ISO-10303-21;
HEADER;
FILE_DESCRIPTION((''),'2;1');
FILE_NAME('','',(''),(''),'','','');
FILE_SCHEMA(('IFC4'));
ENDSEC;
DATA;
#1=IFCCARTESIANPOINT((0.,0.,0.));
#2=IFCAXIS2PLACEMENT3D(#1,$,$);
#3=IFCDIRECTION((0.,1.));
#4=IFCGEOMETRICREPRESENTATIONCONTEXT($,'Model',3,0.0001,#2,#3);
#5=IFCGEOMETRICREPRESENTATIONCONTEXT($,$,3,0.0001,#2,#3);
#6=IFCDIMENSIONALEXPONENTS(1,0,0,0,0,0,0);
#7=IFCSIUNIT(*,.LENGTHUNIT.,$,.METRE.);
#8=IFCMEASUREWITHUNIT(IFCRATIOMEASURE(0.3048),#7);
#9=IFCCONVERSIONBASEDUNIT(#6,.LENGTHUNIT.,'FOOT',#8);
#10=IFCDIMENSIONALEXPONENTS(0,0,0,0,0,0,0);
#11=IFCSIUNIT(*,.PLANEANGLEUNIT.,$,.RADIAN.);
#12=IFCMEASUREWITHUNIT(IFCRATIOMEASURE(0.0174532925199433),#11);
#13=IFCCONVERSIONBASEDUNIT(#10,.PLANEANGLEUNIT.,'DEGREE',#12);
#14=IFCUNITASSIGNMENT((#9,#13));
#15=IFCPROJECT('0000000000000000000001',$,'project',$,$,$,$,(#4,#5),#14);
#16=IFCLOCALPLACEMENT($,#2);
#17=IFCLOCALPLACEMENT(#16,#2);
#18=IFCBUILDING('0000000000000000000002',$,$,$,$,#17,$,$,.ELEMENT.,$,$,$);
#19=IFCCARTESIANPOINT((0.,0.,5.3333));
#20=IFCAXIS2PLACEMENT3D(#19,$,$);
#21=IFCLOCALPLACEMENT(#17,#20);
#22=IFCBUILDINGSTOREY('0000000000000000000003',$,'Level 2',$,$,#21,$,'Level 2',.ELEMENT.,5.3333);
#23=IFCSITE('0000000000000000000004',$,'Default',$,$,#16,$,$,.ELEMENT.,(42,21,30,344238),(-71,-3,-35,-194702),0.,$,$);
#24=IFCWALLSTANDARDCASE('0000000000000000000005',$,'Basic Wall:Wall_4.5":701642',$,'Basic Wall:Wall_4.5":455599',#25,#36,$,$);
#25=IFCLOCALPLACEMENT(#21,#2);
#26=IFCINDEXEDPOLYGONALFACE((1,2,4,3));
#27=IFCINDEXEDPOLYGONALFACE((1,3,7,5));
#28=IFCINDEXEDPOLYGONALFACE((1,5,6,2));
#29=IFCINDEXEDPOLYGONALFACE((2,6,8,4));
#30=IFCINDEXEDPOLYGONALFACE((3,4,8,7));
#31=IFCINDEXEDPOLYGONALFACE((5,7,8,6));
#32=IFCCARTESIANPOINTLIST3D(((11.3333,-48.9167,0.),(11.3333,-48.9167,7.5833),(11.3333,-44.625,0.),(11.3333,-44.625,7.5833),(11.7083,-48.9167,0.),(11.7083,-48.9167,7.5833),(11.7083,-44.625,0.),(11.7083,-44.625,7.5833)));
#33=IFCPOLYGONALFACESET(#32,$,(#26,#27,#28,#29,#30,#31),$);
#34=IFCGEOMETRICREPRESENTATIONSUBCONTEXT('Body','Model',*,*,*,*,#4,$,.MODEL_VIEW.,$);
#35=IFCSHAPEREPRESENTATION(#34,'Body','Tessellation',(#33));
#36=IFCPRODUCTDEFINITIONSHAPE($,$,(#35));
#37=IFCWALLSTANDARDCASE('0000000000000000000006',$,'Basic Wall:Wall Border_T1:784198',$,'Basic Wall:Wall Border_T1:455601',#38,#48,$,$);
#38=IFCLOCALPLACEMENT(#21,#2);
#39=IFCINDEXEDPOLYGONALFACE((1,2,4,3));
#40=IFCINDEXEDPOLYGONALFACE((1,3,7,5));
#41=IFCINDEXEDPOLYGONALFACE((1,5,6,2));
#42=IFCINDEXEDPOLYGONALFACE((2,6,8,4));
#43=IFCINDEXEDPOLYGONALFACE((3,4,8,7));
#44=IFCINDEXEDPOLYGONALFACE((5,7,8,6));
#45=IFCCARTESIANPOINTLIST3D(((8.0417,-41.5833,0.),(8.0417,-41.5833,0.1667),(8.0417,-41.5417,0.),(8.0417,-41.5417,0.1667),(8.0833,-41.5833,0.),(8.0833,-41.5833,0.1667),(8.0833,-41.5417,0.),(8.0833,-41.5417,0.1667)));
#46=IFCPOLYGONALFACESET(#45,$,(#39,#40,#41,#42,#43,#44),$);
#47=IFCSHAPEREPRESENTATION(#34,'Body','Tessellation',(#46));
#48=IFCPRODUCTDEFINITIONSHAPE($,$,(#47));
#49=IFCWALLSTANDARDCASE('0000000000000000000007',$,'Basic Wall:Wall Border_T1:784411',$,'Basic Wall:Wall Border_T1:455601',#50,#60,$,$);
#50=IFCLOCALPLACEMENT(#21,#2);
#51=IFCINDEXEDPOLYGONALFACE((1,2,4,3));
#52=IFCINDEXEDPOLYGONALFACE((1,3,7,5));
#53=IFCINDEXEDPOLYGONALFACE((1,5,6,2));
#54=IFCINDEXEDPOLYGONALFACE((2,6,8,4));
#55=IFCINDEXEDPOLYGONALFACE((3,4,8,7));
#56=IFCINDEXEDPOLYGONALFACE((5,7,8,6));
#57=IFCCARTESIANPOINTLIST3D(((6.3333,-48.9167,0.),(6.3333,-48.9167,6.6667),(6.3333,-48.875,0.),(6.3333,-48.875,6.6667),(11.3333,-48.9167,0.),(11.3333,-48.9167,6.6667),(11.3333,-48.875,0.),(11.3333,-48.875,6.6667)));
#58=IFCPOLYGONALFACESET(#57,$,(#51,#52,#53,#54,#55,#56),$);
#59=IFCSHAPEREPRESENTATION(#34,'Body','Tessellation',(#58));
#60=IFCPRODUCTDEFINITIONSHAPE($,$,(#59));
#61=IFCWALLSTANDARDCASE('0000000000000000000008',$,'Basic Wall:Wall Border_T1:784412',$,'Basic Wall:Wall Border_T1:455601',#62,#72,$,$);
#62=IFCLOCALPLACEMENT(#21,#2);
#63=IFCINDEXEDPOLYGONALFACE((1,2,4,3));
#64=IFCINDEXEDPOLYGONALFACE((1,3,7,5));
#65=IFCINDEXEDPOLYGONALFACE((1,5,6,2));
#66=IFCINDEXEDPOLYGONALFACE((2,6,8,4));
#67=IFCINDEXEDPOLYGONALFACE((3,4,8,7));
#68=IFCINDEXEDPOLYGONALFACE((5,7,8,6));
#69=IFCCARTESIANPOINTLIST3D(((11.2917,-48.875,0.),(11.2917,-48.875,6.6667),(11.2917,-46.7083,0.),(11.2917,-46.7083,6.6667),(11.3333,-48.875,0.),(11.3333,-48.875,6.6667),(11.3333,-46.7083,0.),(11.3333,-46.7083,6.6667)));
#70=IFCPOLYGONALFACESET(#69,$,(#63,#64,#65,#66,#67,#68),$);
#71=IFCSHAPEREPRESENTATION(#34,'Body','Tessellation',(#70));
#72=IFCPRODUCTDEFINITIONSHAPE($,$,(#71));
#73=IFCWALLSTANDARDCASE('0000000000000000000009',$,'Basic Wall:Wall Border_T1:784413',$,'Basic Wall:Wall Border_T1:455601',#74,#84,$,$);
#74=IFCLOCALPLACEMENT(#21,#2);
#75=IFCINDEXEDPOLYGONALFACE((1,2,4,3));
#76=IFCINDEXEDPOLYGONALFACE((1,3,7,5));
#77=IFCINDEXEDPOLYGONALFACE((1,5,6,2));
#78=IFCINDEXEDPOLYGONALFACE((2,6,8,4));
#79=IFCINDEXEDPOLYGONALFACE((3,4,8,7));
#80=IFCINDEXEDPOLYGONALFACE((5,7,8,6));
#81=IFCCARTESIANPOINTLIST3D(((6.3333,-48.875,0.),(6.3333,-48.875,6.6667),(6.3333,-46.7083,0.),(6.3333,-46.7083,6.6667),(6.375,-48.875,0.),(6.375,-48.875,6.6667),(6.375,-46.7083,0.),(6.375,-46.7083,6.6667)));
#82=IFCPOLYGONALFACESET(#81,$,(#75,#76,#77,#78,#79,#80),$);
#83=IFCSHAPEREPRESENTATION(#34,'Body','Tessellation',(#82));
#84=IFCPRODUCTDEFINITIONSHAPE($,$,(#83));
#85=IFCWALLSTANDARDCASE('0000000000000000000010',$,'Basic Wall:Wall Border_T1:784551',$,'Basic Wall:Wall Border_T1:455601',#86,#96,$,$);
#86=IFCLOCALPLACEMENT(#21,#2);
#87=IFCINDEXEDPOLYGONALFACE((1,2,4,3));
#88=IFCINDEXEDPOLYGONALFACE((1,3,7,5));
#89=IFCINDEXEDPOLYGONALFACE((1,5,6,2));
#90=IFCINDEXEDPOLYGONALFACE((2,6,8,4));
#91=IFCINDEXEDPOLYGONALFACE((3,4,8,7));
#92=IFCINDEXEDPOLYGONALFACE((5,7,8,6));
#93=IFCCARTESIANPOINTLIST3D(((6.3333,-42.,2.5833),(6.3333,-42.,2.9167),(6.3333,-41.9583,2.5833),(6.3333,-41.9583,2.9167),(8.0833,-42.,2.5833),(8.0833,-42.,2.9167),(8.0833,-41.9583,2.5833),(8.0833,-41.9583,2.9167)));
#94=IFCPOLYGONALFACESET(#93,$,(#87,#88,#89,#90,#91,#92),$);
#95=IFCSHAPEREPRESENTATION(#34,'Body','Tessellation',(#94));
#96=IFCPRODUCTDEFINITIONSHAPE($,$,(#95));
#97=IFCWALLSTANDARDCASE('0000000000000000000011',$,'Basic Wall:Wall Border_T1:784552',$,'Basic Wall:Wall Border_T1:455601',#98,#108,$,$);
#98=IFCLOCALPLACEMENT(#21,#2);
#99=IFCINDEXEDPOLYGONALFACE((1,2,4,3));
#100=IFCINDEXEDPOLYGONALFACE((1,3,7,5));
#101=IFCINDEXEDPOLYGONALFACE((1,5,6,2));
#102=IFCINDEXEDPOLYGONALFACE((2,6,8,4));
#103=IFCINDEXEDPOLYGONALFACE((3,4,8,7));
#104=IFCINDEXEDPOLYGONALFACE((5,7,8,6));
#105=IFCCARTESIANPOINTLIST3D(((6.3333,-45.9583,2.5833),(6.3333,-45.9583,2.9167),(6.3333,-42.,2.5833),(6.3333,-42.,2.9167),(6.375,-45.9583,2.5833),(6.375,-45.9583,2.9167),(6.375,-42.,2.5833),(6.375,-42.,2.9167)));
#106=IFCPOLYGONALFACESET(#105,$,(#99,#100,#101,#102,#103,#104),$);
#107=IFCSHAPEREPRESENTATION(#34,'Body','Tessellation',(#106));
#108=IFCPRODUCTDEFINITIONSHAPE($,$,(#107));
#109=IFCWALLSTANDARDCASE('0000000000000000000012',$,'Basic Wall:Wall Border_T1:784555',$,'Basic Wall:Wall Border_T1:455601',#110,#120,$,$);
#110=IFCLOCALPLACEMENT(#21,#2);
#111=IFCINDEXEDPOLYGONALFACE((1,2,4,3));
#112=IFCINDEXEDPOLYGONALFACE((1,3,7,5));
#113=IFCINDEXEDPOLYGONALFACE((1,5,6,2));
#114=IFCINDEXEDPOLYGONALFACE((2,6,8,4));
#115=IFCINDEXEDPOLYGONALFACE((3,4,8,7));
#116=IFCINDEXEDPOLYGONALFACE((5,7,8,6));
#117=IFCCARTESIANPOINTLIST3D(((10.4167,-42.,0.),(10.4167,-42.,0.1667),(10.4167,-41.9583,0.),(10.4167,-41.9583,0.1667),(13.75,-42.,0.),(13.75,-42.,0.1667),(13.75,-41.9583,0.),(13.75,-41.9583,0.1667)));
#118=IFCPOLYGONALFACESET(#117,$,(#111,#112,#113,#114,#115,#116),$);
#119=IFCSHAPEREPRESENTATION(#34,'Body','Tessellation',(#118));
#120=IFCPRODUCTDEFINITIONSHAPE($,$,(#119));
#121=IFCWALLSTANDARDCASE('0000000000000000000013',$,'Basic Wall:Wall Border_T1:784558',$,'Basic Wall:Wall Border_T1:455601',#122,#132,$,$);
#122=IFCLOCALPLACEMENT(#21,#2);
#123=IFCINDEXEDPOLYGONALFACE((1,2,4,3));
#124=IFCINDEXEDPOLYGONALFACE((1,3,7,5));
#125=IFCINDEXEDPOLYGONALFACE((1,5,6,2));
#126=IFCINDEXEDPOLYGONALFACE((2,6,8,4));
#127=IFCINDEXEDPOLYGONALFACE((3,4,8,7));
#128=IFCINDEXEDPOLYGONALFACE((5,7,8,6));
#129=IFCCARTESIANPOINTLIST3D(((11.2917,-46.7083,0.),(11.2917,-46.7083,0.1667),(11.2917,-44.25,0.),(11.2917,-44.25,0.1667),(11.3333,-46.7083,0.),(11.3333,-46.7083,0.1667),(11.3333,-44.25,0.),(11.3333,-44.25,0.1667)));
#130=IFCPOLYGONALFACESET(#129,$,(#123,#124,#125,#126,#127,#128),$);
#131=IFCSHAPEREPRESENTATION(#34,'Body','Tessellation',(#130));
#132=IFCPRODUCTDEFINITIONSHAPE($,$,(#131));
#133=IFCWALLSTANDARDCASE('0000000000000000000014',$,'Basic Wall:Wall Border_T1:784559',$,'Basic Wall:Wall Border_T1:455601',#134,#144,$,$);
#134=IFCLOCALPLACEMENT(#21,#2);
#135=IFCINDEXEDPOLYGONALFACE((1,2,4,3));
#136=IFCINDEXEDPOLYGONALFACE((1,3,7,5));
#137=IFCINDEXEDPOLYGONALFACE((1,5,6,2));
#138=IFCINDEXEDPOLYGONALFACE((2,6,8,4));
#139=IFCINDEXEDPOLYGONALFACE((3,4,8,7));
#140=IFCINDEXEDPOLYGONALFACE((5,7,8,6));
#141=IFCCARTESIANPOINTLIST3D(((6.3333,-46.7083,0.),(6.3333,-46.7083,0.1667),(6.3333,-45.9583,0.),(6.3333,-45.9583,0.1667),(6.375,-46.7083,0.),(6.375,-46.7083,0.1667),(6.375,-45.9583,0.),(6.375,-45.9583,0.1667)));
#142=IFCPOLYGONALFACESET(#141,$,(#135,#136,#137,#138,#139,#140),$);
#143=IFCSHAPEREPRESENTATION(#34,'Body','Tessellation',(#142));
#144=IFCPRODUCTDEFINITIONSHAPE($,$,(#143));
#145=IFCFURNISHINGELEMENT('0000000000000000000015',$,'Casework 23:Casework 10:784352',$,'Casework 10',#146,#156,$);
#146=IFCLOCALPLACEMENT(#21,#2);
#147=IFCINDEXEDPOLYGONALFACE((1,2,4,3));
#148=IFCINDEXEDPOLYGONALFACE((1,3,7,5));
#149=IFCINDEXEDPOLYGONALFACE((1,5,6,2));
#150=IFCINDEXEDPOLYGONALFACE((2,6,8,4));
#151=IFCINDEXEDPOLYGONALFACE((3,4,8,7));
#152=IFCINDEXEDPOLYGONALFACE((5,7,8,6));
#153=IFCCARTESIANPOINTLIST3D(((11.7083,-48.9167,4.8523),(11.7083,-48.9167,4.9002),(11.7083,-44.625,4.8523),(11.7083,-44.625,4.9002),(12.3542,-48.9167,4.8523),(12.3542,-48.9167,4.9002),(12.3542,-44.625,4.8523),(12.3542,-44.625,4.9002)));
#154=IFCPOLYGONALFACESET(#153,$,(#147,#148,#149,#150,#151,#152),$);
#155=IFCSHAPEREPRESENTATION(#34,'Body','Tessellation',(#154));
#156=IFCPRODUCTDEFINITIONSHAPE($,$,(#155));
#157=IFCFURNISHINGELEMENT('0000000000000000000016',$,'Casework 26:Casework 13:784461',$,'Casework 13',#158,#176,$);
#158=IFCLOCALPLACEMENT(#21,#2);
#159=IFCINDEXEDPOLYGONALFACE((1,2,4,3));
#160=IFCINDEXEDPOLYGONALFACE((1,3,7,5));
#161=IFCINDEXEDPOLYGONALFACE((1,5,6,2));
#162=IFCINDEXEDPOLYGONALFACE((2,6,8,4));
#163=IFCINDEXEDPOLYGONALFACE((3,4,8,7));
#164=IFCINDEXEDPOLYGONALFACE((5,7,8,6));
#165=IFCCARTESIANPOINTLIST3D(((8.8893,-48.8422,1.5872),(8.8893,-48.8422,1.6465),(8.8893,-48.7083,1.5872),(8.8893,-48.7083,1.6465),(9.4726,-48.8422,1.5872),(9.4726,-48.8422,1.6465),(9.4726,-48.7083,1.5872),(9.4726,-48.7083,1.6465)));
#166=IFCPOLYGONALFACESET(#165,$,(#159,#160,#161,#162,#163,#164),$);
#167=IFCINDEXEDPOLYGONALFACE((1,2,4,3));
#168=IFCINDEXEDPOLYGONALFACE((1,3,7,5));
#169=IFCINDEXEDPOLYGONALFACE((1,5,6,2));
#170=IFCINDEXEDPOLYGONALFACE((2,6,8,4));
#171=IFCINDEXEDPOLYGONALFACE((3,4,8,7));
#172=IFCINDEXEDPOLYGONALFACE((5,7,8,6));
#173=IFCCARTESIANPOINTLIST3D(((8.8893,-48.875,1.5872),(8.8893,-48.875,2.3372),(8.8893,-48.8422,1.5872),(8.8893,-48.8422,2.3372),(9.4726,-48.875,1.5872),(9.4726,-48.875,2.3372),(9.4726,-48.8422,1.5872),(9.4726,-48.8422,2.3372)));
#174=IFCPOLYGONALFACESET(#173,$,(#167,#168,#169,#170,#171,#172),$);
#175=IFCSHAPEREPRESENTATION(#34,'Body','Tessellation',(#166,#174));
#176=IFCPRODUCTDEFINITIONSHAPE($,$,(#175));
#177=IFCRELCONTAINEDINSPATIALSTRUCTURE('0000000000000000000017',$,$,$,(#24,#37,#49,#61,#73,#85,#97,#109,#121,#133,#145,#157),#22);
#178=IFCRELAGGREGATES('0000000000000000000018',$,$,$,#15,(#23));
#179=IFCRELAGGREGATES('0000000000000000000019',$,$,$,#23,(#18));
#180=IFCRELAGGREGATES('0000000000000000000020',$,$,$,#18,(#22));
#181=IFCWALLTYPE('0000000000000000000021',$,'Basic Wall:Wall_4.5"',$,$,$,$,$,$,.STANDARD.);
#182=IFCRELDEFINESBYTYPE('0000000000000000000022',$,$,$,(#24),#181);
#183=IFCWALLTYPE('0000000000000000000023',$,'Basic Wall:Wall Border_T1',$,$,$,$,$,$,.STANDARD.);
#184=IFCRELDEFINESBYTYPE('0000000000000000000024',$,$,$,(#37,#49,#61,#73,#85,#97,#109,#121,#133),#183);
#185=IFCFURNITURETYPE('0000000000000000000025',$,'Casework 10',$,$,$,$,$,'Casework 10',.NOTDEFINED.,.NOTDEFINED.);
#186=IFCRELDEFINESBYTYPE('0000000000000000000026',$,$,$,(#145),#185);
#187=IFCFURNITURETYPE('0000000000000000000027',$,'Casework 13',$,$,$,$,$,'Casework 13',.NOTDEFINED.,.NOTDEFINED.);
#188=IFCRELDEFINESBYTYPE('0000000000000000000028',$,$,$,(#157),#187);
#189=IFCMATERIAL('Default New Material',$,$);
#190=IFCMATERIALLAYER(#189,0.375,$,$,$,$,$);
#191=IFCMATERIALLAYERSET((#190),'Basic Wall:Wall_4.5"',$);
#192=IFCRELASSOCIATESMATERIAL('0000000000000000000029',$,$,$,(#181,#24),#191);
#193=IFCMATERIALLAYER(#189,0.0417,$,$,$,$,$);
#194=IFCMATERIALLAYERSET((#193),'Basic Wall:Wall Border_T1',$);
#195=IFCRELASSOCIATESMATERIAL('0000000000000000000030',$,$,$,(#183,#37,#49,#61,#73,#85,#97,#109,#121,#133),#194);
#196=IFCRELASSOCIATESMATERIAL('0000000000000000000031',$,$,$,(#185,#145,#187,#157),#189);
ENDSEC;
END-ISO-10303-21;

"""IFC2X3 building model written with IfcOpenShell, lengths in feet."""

from ifc_helpers import new_model, entity, si_unit, converted_unit, direction, frame, frame_2d, origin, place, context, subcontext, project, spatial, rectangle, extrude, source, transform, mapped, material, layer, layer_set, layer_usage, type_object, type_shapes, element, save


model = new_model("IFC2X3")

# Units and contexts
model_context = context("Model", 3, precision=0.0001, world=origin(), true_north=direction((0.0, 1.0)))
context_of_model = context(None, 3, precision=0.0001, world=origin(), true_north=direction((0.0, 1.0)))
body_context = subcontext(model_context, "Body", "Model", "MODEL_VIEW")
ifc_project = project(units=[converted_unit("LENGTHUNIT", "FOOT", entity("IfcRatioMeasure", 0.3048), si_unit("LENGTHUNIT", "METRE"), dimensions=[1, 0, 0, 0, 0, 0, 0]), converted_unit("PLANEANGLEUNIT", "DEGREE", entity("IfcRatioMeasure", 0.0174532925199433), si_unit("PLANEANGLEUNIT", "RADIAN"), dimensions=[0, 0, 0, 0, 0, 0, 0])], contexts=[model_context, context_of_model])

# Site, building, storey
site_placement = place(None, origin())
site = spatial("IfcSite", under=ifc_project, at=site_placement, Name="Default", CompositionType="ELEMENT", RefLatitude=(42, 21, 30, 344238), RefLongitude=(-71, -3, -35, -194702), RefElevation=0.0)
building_placement = place(site_placement, origin())
building = spatial("IfcBuilding", under=site, at=building_placement, CompositionType="ELEMENT")
storey_placement = place(building_placement, frame((0.0, 0.0, 5.3333)))
storey = spatial("IfcBuildingStorey", under=building, at=storey_placement, Name="Level 2", LongName="Level 2", CompositionType="ELEMENT", Elevation=5.3333)

# Walls
ifc_material = material(Name="Default New Material")
ifc_layer_1 = layer(ifc_material, 0.375)
ifc_layer_set_1 = layer_set([ifc_layer_1], Name="Basic Wall:Wall_4.5\"")
ifc_layer_usage_1 = layer_usage(ifc_layer_set_1, "AXIS2", "NEGATIVE", 0.1875)
wall_type_1 = type_object("IfcWallType", Name="Basic Wall:Wall_4.5\"", PredefinedType="STANDARD", material=ifc_layer_set_1)
wall_1_placement = place(storey_placement, frame((11.5208, -44.625, 0.0), z_axis=(0.0, 0.0, 1.0), x_axis=(0.0, -1.0, 0.0)))
element("IfcWallStandardCase", 1, at=wall_1_placement, inside=storey, type_object=wall_type_1, material=ifc_layer_usage_1, Name="Basic Wall:Wall_4.5\":701642", ObjectType="Basic Wall:Wall_4.5\":455599", context=body_context, shape_type="SweptSolid", body=[
    extrude(rectangle(XDim=4.2917, YDim=0.375, at=frame_2d((2.1458, 0.0), x_axis=(-1.0, 0.0))), origin(), (0.0, 0.0, 1.0), 7.5833),
])
ifc_layer_2 = layer(ifc_material, 0.0417)
ifc_layer_set_2 = layer_set([ifc_layer_2], Name="Basic Wall:Wall Border_T1")
ifc_layer_usage_2 = layer_usage(ifc_layer_set_2, "AXIS2", "NEGATIVE", 0.0208)
wall_type_2 = type_object("IfcWallType", Name="Basic Wall:Wall Border_T1", PredefinedType="STANDARD", material=ifc_layer_set_2)
wall_2_placement = place(storey_placement, frame((8.0417, -41.5625, 0.0)))
element("IfcWallStandardCase", 2, at=wall_2_placement, inside=storey, type_object=wall_type_2, material=ifc_layer_usage_2, Name="Basic Wall:Wall Border_T1:784198", ObjectType="Basic Wall:Wall Border_T1:455601", context=body_context, shape_type="SweptSolid", body=[
    extrude(rectangle(XDim=0.0417, YDim=0.0417, at=frame_2d((0.0208, 0.0), x_axis=(-1.0, 0.0))), origin(), (0.0, 0.0, 1.0), 0.1667),
])
ifc_layer_usage_3 = layer_usage(ifc_layer_set_2, "AXIS2", "NEGATIVE", 0.0208)
wall_3_placement = place(storey_placement, frame((6.3333, -48.8958, 0.0)))
element("IfcWallStandardCase", 3, at=wall_3_placement, inside=storey, type_object=wall_type_2, material=ifc_layer_usage_3, Name="Basic Wall:Wall Border_T1:784411", ObjectType="Basic Wall:Wall Border_T1:455601", context=body_context, shape_type="SweptSolid", body=[
    extrude(rectangle(XDim=5.0, YDim=0.0417, at=frame_2d((2.5, 0.0), x_axis=(-1.0, 0.0))), origin(), (0.0, 0.0, 1.0), 6.6667),
])
ifc_layer_usage_4 = layer_usage(ifc_layer_set_2, "AXIS2", "NEGATIVE", 0.0208)
wall_4_placement = place(storey_placement, frame((11.3125, -48.875, 0.0), z_axis=(0.0, 0.0, 1.0), x_axis=(0.0, 1.0, 0.0)))
element("IfcWallStandardCase", 4, at=wall_4_placement, inside=storey, type_object=wall_type_2, material=ifc_layer_usage_4, Name="Basic Wall:Wall Border_T1:784412", ObjectType="Basic Wall:Wall Border_T1:455601", context=body_context, shape_type="SweptSolid", body=[
    extrude(rectangle(XDim=2.1667, YDim=0.0417, at=frame_2d((1.0833, 0.0), x_axis=(-1.0, 0.0))), origin(), (0.0, 0.0, 1.0), 6.6667),
])
ifc_layer_usage_5 = layer_usage(ifc_layer_set_2, "AXIS2", "POSITIVE", -0.0208)
wall_5_placement = place(storey_placement, frame((6.3542, -48.875, 0.0), z_axis=(0.0, 0.0, 1.0), x_axis=(0.0, 1.0, 0.0)))
element("IfcWallStandardCase", 5, at=wall_5_placement, inside=storey, type_object=wall_type_2, material=ifc_layer_usage_5, Name="Basic Wall:Wall Border_T1:784413", ObjectType="Basic Wall:Wall Border_T1:455601", context=body_context, shape_type="SweptSolid", body=[
    extrude(rectangle(XDim=2.1667, YDim=0.0417, at=frame_2d((1.0833, 0.0), x_axis=(-1.0, 0.0))), origin(), (0.0, 0.0, 1.0), 6.6667),
])
ifc_layer_usage_6 = layer_usage(ifc_layer_set_2, "AXIS2", "NEGATIVE", 0.0208)
wall_6_placement = place(storey_placement, frame((8.0833, -41.9792, 2.5833), z_axis=(0.0, 0.0, 1.0), x_axis=(-1.0, 0.0, 0.0)))
element("IfcWallStandardCase", 6, at=wall_6_placement, inside=storey, type_object=wall_type_2, material=ifc_layer_usage_6, Name="Basic Wall:Wall Border_T1:784551", ObjectType="Basic Wall:Wall Border_T1:455601", context=body_context, shape_type="SweptSolid", body=[
    extrude(rectangle(XDim=1.75, YDim=0.0417, at=frame_2d((0.875, 0.0), x_axis=(-1.0, 0.0))), origin(), (0.0, 0.0, 1.0), 0.3333),
])
ifc_layer_usage_7 = layer_usage(ifc_layer_set_2, "AXIS2", "NEGATIVE", 0.0208)
wall_7_placement = place(storey_placement, frame((6.3542, -42.0, 2.5833), z_axis=(0.0, 0.0, 1.0), x_axis=(0.0, -1.0, 0.0)))
element("IfcWallStandardCase", 7, at=wall_7_placement, inside=storey, type_object=wall_type_2, material=ifc_layer_usage_7, Name="Basic Wall:Wall Border_T1:784552", ObjectType="Basic Wall:Wall Border_T1:455601", context=body_context, shape_type="SweptSolid", body=[
    extrude(rectangle(XDim=3.9583, YDim=0.0417, at=frame_2d((1.9792, 0.0), x_axis=(-1.0, 0.0))), origin(), (0.0, 0.0, 1.0), 0.3333),
])
ifc_layer_usage_8 = layer_usage(ifc_layer_set_2, "AXIS2", "POSITIVE", -0.0208)
wall_8_placement = place(storey_placement, frame((10.4167, -41.9792, 0.0)))
element("IfcWallStandardCase", 8, at=wall_8_placement, inside=storey, type_object=wall_type_2, material=ifc_layer_usage_8, Name="Basic Wall:Wall Border_T1:784555", ObjectType="Basic Wall:Wall Border_T1:455601", context=body_context, shape_type="SweptSolid", body=[
    extrude(rectangle(XDim=3.3333, YDim=0.0417, at=frame_2d((1.6667, 0.0), x_axis=(-1.0, 0.0))), origin(), (0.0, 0.0, 1.0), 0.1667),
])
ifc_layer_usage_9 = layer_usage(ifc_layer_set_2, "AXIS2", "POSITIVE", -0.0208)
wall_9_placement = place(storey_placement, frame((11.3125, -44.25, 0.0), z_axis=(0.0, 0.0, 1.0), x_axis=(0.0, -1.0, 0.0)))
element("IfcWallStandardCase", 9, at=wall_9_placement, inside=storey, type_object=wall_type_2, material=ifc_layer_usage_9, Name="Basic Wall:Wall Border_T1:784558", ObjectType="Basic Wall:Wall Border_T1:455601", context=body_context, shape_type="SweptSolid", body=[
    extrude(rectangle(XDim=2.4583, YDim=0.0417, at=frame_2d((1.2292, 0.0), x_axis=(-1.0, 0.0))), origin(), (0.0, 0.0, 1.0), 0.1667),
])
ifc_layer_usage_10 = layer_usage(ifc_layer_set_2, "AXIS2", "POSITIVE", -0.0208)
wall_10_placement = place(storey_placement, frame((6.3542, -46.7083, 0.0), z_axis=(0.0, 0.0, 1.0), x_axis=(0.0, 1.0, 0.0)))
element("IfcWallStandardCase", 10, at=wall_10_placement, inside=storey, type_object=wall_type_2, material=ifc_layer_usage_10, Name="Basic Wall:Wall Border_T1:784559", ObjectType="Basic Wall:Wall Border_T1:455601", context=body_context, shape_type="SweptSolid", body=[
    extrude(rectangle(XDim=0.75, YDim=0.0417, at=frame_2d((0.375, 0.0), x_axis=(-1.0, 0.0))), origin(), (0.0, 0.0, 1.0), 0.1667),
])

# Furnishing elements
furniture_type_1 = type_object("IfcFurnitureType", Name="Casework 10", ElementType="Casework 10", AssemblyPlace="NOTDEFINED", material=ifc_material)
shared_shape_1 = source(origin(), body_context, "Body", "SweptSolid", [
    extrude(rectangle(XDim=0.6458, YDim=4.2917, at=frame_2d((0.0, 0.0), x_axis=(1.0, 0.0))), frame((0.3229, 2.1458, 0.0), z_axis=(0.0, 0.0, 1.0), x_axis=(-1.0, 0.0, 0.0)), (0.0, 0.0, 1.0), 0.0479),
])
type_shapes(furniture_type_1, [shared_shape_1])
furnishing_1_placement = place(storey_placement, frame((11.7083, -48.9167, 4.8523)))
element("IfcFurnishingElement", 11, at=furnishing_1_placement, inside=storey, type_object=furniture_type_1, material=ifc_material, Name="Casework 23:Casework 10:784352", ObjectType="Casework 10", context=body_context, shape_type="MappedRepresentation", body=[
    mapped(shared_shape_1, transform((0.0, 0.0, 0.0), scale=1.0)),
])
furniture_type_2 = type_object("IfcFurnitureType", Name="Casework 13", ElementType="Casework 13", AssemblyPlace="NOTDEFINED", material=ifc_material)
shared_shape_2 = source(origin(), body_context, "Body", "SweptSolid", [
    extrude(rectangle(XDim=0.1339, YDim=0.5833, at=frame_2d((0.0, 0.0), x_axis=(1.0, 0.0))), frame((0.2917, 0.0997, 0.0), z_axis=(0.0, 0.0, 1.0), x_axis=(0.0, -1.0, 0.0)), (0.0, 0.0, 1.0), 0.0593),
    extrude(rectangle(XDim=0.0328, YDim=0.5833, at=frame_2d((0.0, 0.0), x_axis=(1.0, 0.0))), frame((0.2917, 0.0164, 0.0), z_axis=(0.0, 0.0, 1.0), x_axis=(0.0, -1.0, 0.0)), (0.0, 0.0, 1.0), 0.75),
])
type_shapes(furniture_type_2, [shared_shape_2])
furnishing_2_placement = place(storey_placement, frame((8.8893, -48.875, 1.5872)))
element("IfcFurnishingElement", 12, at=furnishing_2_placement, inside=storey, type_object=furniture_type_2, material=ifc_material, Name="Casework 26:Casework 13:784461", ObjectType="Casework 13", context=body_context, shape_type="MappedRepresentation", body=[
    mapped(shared_shape_2, transform((0.0, 0.0, 0.0), scale=1.0)),
])

save(model, "model.ifc")
